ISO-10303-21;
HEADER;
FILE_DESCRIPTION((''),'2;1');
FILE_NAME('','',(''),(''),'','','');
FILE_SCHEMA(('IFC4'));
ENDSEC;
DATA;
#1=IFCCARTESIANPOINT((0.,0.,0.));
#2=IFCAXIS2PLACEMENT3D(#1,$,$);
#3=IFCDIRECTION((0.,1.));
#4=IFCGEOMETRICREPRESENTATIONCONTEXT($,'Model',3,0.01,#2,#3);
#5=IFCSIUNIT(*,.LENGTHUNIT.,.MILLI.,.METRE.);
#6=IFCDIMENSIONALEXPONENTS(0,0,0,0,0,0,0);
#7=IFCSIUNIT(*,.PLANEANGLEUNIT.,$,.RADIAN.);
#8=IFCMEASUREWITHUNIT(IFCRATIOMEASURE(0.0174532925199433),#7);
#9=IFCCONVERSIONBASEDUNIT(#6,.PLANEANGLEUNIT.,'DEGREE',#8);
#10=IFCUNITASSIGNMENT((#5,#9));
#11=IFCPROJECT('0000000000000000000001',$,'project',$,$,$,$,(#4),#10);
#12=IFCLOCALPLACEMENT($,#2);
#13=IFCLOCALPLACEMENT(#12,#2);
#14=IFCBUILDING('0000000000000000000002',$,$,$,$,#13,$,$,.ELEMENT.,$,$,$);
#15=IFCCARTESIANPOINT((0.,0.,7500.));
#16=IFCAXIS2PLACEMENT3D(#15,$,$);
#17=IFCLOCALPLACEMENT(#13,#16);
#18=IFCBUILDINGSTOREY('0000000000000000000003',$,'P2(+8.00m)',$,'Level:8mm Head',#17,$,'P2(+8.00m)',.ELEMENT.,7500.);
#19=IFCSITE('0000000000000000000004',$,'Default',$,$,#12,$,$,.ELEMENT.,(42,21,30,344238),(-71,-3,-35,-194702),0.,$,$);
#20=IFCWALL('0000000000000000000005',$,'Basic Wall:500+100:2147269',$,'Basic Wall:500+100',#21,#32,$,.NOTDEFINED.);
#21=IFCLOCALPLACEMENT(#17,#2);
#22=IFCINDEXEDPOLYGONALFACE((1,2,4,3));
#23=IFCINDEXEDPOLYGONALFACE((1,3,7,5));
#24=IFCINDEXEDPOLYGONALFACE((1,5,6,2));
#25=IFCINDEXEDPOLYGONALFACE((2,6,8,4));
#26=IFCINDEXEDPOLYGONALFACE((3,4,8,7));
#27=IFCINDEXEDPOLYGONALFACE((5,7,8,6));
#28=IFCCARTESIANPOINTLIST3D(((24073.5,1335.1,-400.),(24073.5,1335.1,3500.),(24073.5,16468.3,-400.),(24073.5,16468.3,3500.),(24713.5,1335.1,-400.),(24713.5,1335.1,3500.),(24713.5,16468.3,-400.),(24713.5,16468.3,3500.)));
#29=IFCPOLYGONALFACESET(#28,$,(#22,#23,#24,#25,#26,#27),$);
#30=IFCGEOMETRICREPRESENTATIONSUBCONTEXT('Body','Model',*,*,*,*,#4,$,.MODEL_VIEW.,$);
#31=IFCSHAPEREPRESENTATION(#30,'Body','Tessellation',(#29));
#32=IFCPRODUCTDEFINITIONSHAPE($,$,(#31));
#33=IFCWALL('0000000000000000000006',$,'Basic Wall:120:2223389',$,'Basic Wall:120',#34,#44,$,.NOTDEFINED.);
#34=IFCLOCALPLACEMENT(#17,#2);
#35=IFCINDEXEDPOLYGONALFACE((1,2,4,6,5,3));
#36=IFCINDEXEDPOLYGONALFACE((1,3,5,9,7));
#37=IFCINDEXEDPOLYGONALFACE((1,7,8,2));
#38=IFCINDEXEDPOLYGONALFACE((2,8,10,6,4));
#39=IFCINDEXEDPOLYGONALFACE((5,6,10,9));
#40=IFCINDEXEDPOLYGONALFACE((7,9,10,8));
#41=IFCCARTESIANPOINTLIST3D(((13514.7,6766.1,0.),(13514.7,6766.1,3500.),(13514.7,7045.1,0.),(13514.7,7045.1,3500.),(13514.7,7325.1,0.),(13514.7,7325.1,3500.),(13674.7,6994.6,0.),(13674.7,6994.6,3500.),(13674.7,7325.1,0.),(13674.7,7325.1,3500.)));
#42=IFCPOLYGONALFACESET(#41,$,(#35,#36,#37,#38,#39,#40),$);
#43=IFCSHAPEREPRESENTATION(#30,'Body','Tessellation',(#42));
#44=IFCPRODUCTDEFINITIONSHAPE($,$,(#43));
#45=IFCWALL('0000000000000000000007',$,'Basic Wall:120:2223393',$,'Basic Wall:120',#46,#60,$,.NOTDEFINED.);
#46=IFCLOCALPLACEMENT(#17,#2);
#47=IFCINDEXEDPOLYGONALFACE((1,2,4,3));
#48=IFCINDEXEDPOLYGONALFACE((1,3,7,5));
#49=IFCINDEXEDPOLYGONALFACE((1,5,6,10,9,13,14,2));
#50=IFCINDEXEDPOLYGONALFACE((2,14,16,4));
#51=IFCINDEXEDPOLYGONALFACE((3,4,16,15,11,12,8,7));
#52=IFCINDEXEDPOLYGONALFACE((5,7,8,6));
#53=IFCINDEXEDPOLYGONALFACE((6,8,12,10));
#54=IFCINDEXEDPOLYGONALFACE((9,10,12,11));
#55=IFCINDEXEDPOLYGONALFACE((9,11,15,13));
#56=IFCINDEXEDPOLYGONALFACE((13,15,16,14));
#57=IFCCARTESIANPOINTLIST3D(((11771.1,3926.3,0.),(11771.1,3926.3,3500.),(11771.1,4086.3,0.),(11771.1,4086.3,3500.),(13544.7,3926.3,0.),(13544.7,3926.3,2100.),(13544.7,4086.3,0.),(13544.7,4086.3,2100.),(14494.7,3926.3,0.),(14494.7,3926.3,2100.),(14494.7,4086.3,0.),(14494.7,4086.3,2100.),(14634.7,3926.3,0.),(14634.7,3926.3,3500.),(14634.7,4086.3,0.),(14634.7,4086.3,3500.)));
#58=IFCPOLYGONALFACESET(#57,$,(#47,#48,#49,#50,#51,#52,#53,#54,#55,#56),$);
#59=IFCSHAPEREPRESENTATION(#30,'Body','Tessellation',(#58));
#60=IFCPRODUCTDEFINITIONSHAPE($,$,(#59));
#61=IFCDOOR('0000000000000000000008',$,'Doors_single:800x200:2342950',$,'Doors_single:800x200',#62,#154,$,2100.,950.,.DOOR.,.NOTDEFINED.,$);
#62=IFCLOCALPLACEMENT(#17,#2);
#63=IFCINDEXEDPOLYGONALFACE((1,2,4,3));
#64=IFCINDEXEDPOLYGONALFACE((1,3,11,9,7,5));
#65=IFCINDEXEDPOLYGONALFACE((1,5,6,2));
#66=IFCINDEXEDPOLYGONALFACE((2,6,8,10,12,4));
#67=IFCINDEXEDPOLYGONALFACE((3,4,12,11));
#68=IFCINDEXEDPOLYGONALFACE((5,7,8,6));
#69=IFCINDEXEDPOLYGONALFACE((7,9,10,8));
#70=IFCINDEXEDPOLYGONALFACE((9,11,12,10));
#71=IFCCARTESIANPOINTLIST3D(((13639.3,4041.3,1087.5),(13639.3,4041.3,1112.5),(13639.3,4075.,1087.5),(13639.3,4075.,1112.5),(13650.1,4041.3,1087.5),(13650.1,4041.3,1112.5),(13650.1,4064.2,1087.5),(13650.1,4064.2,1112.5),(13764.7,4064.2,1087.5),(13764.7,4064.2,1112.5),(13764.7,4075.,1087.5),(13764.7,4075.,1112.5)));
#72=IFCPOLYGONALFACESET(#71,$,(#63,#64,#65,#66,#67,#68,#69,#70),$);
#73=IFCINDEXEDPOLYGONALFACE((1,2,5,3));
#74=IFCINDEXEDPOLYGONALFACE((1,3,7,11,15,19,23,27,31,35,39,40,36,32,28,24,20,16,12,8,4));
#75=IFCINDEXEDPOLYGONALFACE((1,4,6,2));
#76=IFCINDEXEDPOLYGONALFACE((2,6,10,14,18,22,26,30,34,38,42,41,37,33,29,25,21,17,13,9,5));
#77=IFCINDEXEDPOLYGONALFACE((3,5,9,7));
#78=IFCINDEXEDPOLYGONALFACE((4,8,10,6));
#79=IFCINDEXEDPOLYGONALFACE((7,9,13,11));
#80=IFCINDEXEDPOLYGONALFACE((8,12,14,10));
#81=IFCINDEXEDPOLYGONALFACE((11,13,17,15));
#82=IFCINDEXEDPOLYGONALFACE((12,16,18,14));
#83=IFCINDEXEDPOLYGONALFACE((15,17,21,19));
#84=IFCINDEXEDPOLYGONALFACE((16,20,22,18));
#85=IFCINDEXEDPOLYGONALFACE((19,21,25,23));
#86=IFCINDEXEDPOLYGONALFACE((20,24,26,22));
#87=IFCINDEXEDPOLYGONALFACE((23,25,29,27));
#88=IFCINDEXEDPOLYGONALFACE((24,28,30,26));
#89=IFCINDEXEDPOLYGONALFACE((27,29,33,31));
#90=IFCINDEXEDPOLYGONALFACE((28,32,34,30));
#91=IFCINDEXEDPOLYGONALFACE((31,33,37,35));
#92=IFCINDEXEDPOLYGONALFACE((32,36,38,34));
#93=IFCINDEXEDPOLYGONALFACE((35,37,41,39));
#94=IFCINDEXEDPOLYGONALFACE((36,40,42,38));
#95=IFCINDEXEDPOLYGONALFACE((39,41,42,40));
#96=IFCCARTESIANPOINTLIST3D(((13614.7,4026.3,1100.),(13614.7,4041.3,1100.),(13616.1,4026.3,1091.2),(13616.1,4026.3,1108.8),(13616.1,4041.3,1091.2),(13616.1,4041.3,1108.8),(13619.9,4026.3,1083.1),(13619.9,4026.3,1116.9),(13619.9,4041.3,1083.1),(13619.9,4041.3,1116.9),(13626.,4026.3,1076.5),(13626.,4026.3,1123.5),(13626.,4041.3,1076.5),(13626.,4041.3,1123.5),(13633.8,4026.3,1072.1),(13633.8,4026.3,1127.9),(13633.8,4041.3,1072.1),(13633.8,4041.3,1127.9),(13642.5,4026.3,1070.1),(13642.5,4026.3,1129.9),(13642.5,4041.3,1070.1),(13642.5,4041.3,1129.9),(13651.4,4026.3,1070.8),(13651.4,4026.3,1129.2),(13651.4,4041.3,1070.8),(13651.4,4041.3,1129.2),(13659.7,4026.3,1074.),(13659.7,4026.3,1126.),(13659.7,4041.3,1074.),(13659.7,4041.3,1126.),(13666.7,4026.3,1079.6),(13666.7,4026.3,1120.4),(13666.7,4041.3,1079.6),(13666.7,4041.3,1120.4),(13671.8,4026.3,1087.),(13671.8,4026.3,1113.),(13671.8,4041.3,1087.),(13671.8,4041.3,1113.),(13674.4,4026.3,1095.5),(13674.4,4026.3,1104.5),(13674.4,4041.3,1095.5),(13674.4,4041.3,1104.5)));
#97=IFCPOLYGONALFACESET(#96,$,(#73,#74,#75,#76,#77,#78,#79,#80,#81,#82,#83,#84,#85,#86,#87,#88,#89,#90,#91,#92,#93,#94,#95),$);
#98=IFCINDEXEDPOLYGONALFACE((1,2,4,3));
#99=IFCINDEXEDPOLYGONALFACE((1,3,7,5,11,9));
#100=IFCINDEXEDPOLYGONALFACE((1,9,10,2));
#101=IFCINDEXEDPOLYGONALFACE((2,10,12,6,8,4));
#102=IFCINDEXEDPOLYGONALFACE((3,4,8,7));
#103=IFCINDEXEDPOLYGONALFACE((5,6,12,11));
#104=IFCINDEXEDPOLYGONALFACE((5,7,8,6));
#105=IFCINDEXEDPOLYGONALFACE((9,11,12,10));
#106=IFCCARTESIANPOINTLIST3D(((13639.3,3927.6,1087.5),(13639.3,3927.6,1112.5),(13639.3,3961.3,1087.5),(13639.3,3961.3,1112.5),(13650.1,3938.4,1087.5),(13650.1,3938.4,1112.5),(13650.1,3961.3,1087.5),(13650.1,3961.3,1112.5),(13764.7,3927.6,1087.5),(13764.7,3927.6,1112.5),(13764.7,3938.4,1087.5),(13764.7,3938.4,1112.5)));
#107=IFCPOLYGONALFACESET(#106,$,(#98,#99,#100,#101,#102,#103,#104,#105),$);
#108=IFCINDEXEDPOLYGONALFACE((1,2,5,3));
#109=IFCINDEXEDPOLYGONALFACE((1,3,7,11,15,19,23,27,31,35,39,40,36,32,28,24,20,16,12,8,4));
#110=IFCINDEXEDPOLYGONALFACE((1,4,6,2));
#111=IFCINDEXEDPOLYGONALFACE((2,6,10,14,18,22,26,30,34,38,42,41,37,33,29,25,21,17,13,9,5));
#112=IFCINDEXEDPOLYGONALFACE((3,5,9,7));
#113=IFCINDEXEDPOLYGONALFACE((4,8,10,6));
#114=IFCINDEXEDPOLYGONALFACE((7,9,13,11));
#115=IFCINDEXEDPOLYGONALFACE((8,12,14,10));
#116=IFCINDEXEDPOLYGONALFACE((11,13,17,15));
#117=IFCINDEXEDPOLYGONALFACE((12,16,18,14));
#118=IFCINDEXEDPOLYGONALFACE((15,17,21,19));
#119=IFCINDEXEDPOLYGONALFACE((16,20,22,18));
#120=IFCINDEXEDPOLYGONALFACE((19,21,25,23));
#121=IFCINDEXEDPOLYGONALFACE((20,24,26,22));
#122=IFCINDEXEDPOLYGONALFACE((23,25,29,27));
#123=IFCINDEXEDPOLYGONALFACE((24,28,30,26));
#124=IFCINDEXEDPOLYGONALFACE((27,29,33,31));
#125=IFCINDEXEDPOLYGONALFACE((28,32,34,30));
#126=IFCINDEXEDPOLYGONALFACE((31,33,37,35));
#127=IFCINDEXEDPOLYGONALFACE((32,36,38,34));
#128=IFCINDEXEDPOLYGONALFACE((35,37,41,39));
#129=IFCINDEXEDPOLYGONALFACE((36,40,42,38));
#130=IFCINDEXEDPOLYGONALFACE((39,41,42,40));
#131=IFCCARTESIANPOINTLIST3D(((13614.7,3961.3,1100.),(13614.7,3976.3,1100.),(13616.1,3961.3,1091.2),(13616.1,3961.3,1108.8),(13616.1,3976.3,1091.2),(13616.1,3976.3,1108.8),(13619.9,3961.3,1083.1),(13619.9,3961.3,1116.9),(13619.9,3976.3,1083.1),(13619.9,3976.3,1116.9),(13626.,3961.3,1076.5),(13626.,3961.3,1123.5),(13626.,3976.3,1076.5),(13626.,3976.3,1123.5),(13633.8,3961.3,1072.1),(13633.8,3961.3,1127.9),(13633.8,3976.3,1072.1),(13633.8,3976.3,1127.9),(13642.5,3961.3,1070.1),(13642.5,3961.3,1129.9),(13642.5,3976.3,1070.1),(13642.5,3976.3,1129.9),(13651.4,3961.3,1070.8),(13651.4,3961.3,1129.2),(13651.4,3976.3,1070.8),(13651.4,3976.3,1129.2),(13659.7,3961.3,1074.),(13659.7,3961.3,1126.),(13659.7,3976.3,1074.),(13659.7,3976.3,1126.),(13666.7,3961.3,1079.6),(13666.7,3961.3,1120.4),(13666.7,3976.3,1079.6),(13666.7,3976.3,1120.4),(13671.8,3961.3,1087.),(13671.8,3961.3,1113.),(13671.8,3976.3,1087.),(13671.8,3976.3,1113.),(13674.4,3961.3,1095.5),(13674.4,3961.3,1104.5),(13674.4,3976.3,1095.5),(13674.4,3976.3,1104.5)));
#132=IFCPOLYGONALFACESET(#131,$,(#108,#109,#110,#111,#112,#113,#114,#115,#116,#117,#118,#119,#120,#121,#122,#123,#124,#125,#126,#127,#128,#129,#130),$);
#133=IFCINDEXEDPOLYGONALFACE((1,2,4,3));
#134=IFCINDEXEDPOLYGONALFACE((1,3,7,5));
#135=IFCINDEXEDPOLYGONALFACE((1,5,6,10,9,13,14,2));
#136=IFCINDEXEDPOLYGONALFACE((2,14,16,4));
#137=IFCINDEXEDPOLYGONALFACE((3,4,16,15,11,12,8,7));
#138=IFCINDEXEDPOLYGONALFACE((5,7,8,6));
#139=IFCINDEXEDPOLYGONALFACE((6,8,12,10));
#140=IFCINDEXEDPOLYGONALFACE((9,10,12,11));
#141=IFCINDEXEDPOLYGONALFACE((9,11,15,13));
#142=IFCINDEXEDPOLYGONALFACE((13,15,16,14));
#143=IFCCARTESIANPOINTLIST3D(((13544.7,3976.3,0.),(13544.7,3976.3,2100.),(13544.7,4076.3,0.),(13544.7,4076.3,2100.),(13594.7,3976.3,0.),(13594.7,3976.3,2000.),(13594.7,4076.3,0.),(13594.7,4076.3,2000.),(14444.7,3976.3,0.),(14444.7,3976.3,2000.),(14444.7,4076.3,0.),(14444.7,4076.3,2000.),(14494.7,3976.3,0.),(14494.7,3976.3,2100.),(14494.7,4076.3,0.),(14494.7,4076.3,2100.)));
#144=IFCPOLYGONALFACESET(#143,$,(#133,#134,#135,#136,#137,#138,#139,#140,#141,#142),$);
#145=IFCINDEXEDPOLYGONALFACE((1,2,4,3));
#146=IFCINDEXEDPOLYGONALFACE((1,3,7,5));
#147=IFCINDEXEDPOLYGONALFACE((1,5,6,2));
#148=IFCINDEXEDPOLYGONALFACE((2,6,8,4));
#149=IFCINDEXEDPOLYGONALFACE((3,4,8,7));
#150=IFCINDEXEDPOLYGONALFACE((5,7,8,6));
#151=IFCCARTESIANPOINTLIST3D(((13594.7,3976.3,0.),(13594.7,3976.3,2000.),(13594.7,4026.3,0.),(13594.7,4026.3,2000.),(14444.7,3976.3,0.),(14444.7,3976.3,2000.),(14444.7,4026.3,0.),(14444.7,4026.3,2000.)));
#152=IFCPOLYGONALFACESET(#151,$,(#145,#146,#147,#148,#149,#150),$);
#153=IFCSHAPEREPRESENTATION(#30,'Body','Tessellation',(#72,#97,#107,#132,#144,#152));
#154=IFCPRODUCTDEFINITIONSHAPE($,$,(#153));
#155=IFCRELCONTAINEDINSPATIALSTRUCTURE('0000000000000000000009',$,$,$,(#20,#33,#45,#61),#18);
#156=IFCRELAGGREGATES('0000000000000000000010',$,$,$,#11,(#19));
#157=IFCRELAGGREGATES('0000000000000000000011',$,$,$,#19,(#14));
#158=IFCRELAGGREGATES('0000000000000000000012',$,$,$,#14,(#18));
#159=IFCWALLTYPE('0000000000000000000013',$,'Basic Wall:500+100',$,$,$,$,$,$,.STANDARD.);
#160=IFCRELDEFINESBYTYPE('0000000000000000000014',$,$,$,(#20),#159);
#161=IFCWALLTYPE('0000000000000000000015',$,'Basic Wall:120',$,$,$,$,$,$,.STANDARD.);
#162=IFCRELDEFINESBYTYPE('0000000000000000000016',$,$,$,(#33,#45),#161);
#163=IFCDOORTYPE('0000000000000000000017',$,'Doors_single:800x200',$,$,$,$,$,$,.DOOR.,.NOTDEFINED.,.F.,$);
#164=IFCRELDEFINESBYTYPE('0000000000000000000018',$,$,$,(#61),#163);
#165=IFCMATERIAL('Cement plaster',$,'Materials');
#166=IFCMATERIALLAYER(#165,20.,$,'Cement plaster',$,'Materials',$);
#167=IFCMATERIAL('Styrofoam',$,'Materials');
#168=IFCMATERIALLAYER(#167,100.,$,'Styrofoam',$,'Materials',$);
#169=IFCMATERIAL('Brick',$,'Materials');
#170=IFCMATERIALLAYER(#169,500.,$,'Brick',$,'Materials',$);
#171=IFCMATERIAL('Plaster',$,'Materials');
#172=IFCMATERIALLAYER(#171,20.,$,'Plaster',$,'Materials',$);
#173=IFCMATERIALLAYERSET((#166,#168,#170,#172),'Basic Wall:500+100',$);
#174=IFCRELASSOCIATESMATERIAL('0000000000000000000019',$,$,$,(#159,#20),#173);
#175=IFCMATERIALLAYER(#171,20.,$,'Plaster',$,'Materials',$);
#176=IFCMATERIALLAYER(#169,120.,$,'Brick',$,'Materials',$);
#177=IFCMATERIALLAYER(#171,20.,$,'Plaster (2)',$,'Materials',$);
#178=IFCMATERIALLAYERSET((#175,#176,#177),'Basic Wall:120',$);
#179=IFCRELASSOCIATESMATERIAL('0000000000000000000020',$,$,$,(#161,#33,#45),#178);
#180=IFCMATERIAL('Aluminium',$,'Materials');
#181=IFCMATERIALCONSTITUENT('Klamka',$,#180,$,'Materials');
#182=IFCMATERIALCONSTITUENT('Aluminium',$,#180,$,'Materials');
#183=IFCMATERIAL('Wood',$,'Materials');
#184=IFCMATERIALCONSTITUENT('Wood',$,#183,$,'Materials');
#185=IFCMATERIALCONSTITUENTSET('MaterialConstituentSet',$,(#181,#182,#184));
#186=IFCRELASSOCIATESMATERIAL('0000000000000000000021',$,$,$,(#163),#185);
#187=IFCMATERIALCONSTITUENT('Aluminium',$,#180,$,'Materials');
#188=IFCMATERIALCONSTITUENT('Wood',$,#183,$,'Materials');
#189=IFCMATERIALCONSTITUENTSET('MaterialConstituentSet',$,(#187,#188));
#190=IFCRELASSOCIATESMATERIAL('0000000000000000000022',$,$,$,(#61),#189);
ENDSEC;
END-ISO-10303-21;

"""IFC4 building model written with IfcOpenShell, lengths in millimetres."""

from ifc_helpers import new_model, entity, si_unit, converted_unit, direction, frame, frame_2d, origin, origin_2d_with_axis, place, context, subcontext, project, spatial, polyline, rectangle, circle, outline, extrude, source, transform, mapped, material, layer, layer_set, layer_usage, constituent, constituent_set, type_object, type_shapes, element, fill, save


model = new_model("IFC4")

# Units and contexts
model_context = context("Model", 3, precision=0.01, world=origin(), true_north=direction((0.0, 1.0)))
body_context = subcontext(model_context, "Body", "Model", "MODEL_VIEW")
ifc_project = project(units=[si_unit("LENGTHUNIT", "METRE", prefix="MILLI"), converted_unit("PLANEANGLEUNIT", "DEGREE", entity("IfcRatioMeasure", 0.0174532925199433), si_unit("PLANEANGLEUNIT", "RADIAN"), dimensions=[0, 0, 0, 0, 0, 0, 0])], contexts=[model_context])

# Site, building, storey
site_placement = place(None, origin())
site = spatial("IfcSite", under=ifc_project, at=site_placement, Name="Default", CompositionType="ELEMENT", RefLatitude=(42, 21, 30, 344238), RefLongitude=(-71, -3, -35, -194702), RefElevation=0.0)
building_placement = place(site_placement, origin())
building = spatial("IfcBuilding", under=site, at=building_placement, CompositionType="ELEMENT")
storey_placement = place(building_placement, frame((0.0, 0.0, 7500.0)))
storey = spatial("IfcBuildingStorey", under=building, at=storey_placement, Name="P2(+8.00m)", ObjectType="Level:8mm Head", LongName="P2(+8.00m)", CompositionType="ELEMENT", Elevation=7500.0)

# Shared definitions
ifc_material_1 = material(Name="Cement plaster", Category="Materials")
ifc_layer_1 = layer(ifc_material_1, 20.0, Name="Cement plaster", Category="Materials")
ifc_material_2 = material(Name="Styrofoam", Category="Materials")
ifc_layer_2 = layer(ifc_material_2, 100.0, Name="Styrofoam", Category="Materials")
ifc_material_3 = material(Name="Brick", Category="Materials")
ifc_layer_3 = layer(ifc_material_3, 500.0, Name="Brick", Category="Materials")
ifc_material_4 = material(Name="Plaster", Category="Materials")
ifc_layer_4 = layer(ifc_material_4, 20.0, Name="Plaster", Category="Materials")
ifc_layer_set_1 = layer_set([ifc_layer_1, ifc_layer_2, ifc_layer_3, ifc_layer_4], Name="Basic Wall:500+100")
wall_type_1 = type_object("IfcWallType", Name="Basic Wall:500+100", PredefinedType="STANDARD", material=ifc_layer_set_1)

# Walls
ifc_layer_usage_1 = layer_usage(ifc_layer_set_1, "AXIS2", "POSITIVE", -320.0)
wall_1_placement = place(storey_placement, frame((24393.5, 1335.1, -400.0), z_axis=(0.0, 0.0, 1.0), x_axis=(0.0, 1.0, 0.0)))
element("IfcWall", 1, at=wall_1_placement, inside=storey, type_object=wall_type_1, material=ifc_layer_usage_1, Name="Basic Wall:500+100:2147269", ObjectType="Basic Wall:500+100", PredefinedType="NOTDEFINED", context=body_context, shape_type="SweptSolid", body=[
    extrude(rectangle(XDim=15133.3, YDim=640.0, at=frame_2d((7566.6, 0.0), x_axis=(-1.0, 0.0))), origin(), (0.0, 0.0, 1.0), 3900.0),
])
ifc_layer_5 = layer(ifc_material_4, 20.0, Name="Plaster", Category="Materials")
ifc_layer_6 = layer(ifc_material_3, 120.0, Name="Brick", Category="Materials")
ifc_layer_7 = layer(ifc_material_4, 20.0, Name="Plaster (2)", Category="Materials")
ifc_layer_set_2 = layer_set([ifc_layer_5, ifc_layer_6, ifc_layer_7], Name="Basic Wall:120")
ifc_layer_usage_2 = layer_usage(ifc_layer_set_2, "AXIS2", "POSITIVE", -80.0)
wall_type_2 = type_object("IfcWallType", Name="Basic Wall:120", PredefinedType="STANDARD", material=ifc_layer_set_2)
wall_2_placement = place(storey_placement, frame((13594.7, 7325.1, 0.0), z_axis=(0.0, 0.0, 1.0), x_axis=(0.0, -1.0, 0.0)))
element("IfcWall", 2, at=wall_2_placement, inside=storey, type_object=wall_type_2, material=ifc_layer_usage_2, Name="Basic Wall:120:2223389", ObjectType="Basic Wall:120", PredefinedType="NOTDEFINED", context=body_context, shape_type="SweptSolid", body=[
    extrude(outline(polyline([(559.0, -80.0), (330.4, 80.0), (0.0, 80.0), (0.0, -80.0), (280.0, -80.0), (559.0, -80.0)])), origin(), (0.0, 0.0, 1.0), 3500.0),
])

# Wall, opening, door
ifc_layer_usage_3 = layer_usage(ifc_layer_set_2, "AXIS2", "POSITIVE", -80.0)
wall_3_placement = place(storey_placement, frame((14634.7, 4006.3, 0.0), z_axis=(0.0, 0.0, 1.0), x_axis=(-1.0, 0.0, 0.0)))
wall_3 = element("IfcWall", 3, at=wall_3_placement, inside=storey, type_object=wall_type_2, material=ifc_layer_usage_3, Name="Basic Wall:120:2223393", ObjectType="Basic Wall:120", PredefinedType="NOTDEFINED", context=body_context, shape_type="SweptSolid", body=[
    extrude(rectangle(XDim=2863.6, YDim=160.0, at=frame_2d((1431.8, 0.0), x_axis=(-1.0, 0.0))), origin(), (0.0, 0.0, 1.0), 3500.0),
])
opening_1_placement = place(wall_3_placement, frame((140.0, -80.0, 0.0)))
opening_1 = element("IfcOpeningElement", 4, at=opening_1_placement, cuts=wall_3, PredefinedType="OPENING", context=body_context, shape_type="SweptSolid", body=[
    extrude(rectangle(XDim=2100.0, YDim=950.0, at=frame_2d((1050.0, 475.0), x_axis=(1.0, 0.0))), frame((0.0, 0.0, 0.0), z_axis=(0.0, 1.0, 0.0), x_axis=(0.0, 0.0, 1.0)), (0.0, 0.0, 1.0), 160.0),
])
ifc_material_5 = material(Name="Aluminium", Category="Materials")
ifc_constituent_1 = constituent(ifc_material_5, Name="Aluminium", Category="Materials")
ifc_material_6 = material(Name="Wood", Category="Materials")
ifc_constituent_2 = constituent(ifc_material_6, Name="Wood", Category="Materials")
ifc_constituent_set_1 = constituent_set(constituents=[ifc_constituent_1, ifc_constituent_2], Name="MaterialConstituentSet")
ifc_constituent_3 = constituent(ifc_material_5, Name="Klamka", Category="Materials")
ifc_constituent_4 = constituent(ifc_material_5, Name="Aluminium", Category="Materials")
ifc_constituent_5 = constituent(ifc_material_6, Name="Wood", Category="Materials")
ifc_constituent_set_2 = constituent_set(constituents=[ifc_constituent_3, ifc_constituent_4, ifc_constituent_5], Name="MaterialConstituentSet")
door_type_1 = type_object("IfcDoorType", Name="Doors_single:800x200", OperationType="NOTDEFINED", ParameterTakesPrecedence=False, PredefinedType="DOOR", material=ifc_constituent_set_2)
shared_shape_1 = source(origin(), body_context, "Body", "SweptSolid", [
    extrude(outline(polyline([(-45.4, -18.9), (-34.6, -18.9), (-34.6, 4.0), (80.0, 4.0), (80.0, 14.8), (-45.4, 14.8), (-45.4, -18.9)])), frame((810.0, 26.1, 1087.5), z_axis=(0.0, 0.0, 1.0), x_axis=(-1.0, 0.0, 0.0)), (0.0, 0.0, 1.0), 25.0),
    extrude(circle(Radius=30.0, at=origin_2d_with_axis()), frame((850.0, 45.0, 1100.0), z_axis=(0.0, 1.0, 0.0), x_axis=(1.0, 0.0, 0.0)), (0.0, 0.0, 1.0), 15.0),
    extrude(outline(polyline([(-18.9, -45.4), (14.8, -45.4), (14.8, 80.0), (4.0, 80.0), (4.0, -34.6), (-18.9, -34.6), (-18.9, -45.4)])), frame((810.0, 143.9, 1087.5), z_axis=(0.0, 0.0, 1.0), x_axis=(0.0, 1.0, 0.0)), (0.0, 0.0, 1.0), 25.0),
    extrude(circle(Radius=30.0, at=origin_2d_with_axis()), frame((850.0, 110.0, 1100.0), z_axis=(0.0, 1.0, 0.0), x_axis=(1.0, 0.0, 0.0)), (0.0, 0.0, 1.0), 15.0),
    extrude(outline(polyline([(-475.0, -1025.0), (-425.0, -1025.0), (-425.0, 975.0), (425.0, 975.0), (425.0, -1025.0), (475.0, -1025.0), (475.0, 1075.0), (-475.0, 1075.0), (-475.0, -1025.0)])), frame((475.0, 10.0, 1025.0), z_axis=(0.0, 1.0, 0.0), x_axis=(-1.0, 0.0, 0.0)), (0.0, 0.0, 1.0), 100.0),
    extrude(rectangle(XDim=850.0, YDim=50.0, at=origin_2d_with_axis()), frame((475.0, 85.0, 0.0), z_axis=(0.0, 0.0, 1.0), x_axis=(-1.0, 0.0, 0.0)), (0.0, 0.0, 1.0), 2000.0),
])
type_shapes(door_type_1, [shared_shape_1])
door_1_placement = place(opening_1_placement, origin())
door_1 = element("IfcDoor", 5, at=door_1_placement, inside=storey, type_object=door_type_1, material=ifc_constituent_set_1, Name="Doors_single:800x200:2342950", ObjectType="Doors_single:800x200", OperationType="NOTDEFINED", OverallHeight=2100.0, OverallWidth=950.0, PredefinedType="DOOR", context=body_context, shape_type="MappedRepresentation", body=[
    mapped(shared_shape_1, transform((0.0, 0.0, 0.0), scale=1.0)),
])
fill(opening_1, door_1)

save(model, "model.ifc")
